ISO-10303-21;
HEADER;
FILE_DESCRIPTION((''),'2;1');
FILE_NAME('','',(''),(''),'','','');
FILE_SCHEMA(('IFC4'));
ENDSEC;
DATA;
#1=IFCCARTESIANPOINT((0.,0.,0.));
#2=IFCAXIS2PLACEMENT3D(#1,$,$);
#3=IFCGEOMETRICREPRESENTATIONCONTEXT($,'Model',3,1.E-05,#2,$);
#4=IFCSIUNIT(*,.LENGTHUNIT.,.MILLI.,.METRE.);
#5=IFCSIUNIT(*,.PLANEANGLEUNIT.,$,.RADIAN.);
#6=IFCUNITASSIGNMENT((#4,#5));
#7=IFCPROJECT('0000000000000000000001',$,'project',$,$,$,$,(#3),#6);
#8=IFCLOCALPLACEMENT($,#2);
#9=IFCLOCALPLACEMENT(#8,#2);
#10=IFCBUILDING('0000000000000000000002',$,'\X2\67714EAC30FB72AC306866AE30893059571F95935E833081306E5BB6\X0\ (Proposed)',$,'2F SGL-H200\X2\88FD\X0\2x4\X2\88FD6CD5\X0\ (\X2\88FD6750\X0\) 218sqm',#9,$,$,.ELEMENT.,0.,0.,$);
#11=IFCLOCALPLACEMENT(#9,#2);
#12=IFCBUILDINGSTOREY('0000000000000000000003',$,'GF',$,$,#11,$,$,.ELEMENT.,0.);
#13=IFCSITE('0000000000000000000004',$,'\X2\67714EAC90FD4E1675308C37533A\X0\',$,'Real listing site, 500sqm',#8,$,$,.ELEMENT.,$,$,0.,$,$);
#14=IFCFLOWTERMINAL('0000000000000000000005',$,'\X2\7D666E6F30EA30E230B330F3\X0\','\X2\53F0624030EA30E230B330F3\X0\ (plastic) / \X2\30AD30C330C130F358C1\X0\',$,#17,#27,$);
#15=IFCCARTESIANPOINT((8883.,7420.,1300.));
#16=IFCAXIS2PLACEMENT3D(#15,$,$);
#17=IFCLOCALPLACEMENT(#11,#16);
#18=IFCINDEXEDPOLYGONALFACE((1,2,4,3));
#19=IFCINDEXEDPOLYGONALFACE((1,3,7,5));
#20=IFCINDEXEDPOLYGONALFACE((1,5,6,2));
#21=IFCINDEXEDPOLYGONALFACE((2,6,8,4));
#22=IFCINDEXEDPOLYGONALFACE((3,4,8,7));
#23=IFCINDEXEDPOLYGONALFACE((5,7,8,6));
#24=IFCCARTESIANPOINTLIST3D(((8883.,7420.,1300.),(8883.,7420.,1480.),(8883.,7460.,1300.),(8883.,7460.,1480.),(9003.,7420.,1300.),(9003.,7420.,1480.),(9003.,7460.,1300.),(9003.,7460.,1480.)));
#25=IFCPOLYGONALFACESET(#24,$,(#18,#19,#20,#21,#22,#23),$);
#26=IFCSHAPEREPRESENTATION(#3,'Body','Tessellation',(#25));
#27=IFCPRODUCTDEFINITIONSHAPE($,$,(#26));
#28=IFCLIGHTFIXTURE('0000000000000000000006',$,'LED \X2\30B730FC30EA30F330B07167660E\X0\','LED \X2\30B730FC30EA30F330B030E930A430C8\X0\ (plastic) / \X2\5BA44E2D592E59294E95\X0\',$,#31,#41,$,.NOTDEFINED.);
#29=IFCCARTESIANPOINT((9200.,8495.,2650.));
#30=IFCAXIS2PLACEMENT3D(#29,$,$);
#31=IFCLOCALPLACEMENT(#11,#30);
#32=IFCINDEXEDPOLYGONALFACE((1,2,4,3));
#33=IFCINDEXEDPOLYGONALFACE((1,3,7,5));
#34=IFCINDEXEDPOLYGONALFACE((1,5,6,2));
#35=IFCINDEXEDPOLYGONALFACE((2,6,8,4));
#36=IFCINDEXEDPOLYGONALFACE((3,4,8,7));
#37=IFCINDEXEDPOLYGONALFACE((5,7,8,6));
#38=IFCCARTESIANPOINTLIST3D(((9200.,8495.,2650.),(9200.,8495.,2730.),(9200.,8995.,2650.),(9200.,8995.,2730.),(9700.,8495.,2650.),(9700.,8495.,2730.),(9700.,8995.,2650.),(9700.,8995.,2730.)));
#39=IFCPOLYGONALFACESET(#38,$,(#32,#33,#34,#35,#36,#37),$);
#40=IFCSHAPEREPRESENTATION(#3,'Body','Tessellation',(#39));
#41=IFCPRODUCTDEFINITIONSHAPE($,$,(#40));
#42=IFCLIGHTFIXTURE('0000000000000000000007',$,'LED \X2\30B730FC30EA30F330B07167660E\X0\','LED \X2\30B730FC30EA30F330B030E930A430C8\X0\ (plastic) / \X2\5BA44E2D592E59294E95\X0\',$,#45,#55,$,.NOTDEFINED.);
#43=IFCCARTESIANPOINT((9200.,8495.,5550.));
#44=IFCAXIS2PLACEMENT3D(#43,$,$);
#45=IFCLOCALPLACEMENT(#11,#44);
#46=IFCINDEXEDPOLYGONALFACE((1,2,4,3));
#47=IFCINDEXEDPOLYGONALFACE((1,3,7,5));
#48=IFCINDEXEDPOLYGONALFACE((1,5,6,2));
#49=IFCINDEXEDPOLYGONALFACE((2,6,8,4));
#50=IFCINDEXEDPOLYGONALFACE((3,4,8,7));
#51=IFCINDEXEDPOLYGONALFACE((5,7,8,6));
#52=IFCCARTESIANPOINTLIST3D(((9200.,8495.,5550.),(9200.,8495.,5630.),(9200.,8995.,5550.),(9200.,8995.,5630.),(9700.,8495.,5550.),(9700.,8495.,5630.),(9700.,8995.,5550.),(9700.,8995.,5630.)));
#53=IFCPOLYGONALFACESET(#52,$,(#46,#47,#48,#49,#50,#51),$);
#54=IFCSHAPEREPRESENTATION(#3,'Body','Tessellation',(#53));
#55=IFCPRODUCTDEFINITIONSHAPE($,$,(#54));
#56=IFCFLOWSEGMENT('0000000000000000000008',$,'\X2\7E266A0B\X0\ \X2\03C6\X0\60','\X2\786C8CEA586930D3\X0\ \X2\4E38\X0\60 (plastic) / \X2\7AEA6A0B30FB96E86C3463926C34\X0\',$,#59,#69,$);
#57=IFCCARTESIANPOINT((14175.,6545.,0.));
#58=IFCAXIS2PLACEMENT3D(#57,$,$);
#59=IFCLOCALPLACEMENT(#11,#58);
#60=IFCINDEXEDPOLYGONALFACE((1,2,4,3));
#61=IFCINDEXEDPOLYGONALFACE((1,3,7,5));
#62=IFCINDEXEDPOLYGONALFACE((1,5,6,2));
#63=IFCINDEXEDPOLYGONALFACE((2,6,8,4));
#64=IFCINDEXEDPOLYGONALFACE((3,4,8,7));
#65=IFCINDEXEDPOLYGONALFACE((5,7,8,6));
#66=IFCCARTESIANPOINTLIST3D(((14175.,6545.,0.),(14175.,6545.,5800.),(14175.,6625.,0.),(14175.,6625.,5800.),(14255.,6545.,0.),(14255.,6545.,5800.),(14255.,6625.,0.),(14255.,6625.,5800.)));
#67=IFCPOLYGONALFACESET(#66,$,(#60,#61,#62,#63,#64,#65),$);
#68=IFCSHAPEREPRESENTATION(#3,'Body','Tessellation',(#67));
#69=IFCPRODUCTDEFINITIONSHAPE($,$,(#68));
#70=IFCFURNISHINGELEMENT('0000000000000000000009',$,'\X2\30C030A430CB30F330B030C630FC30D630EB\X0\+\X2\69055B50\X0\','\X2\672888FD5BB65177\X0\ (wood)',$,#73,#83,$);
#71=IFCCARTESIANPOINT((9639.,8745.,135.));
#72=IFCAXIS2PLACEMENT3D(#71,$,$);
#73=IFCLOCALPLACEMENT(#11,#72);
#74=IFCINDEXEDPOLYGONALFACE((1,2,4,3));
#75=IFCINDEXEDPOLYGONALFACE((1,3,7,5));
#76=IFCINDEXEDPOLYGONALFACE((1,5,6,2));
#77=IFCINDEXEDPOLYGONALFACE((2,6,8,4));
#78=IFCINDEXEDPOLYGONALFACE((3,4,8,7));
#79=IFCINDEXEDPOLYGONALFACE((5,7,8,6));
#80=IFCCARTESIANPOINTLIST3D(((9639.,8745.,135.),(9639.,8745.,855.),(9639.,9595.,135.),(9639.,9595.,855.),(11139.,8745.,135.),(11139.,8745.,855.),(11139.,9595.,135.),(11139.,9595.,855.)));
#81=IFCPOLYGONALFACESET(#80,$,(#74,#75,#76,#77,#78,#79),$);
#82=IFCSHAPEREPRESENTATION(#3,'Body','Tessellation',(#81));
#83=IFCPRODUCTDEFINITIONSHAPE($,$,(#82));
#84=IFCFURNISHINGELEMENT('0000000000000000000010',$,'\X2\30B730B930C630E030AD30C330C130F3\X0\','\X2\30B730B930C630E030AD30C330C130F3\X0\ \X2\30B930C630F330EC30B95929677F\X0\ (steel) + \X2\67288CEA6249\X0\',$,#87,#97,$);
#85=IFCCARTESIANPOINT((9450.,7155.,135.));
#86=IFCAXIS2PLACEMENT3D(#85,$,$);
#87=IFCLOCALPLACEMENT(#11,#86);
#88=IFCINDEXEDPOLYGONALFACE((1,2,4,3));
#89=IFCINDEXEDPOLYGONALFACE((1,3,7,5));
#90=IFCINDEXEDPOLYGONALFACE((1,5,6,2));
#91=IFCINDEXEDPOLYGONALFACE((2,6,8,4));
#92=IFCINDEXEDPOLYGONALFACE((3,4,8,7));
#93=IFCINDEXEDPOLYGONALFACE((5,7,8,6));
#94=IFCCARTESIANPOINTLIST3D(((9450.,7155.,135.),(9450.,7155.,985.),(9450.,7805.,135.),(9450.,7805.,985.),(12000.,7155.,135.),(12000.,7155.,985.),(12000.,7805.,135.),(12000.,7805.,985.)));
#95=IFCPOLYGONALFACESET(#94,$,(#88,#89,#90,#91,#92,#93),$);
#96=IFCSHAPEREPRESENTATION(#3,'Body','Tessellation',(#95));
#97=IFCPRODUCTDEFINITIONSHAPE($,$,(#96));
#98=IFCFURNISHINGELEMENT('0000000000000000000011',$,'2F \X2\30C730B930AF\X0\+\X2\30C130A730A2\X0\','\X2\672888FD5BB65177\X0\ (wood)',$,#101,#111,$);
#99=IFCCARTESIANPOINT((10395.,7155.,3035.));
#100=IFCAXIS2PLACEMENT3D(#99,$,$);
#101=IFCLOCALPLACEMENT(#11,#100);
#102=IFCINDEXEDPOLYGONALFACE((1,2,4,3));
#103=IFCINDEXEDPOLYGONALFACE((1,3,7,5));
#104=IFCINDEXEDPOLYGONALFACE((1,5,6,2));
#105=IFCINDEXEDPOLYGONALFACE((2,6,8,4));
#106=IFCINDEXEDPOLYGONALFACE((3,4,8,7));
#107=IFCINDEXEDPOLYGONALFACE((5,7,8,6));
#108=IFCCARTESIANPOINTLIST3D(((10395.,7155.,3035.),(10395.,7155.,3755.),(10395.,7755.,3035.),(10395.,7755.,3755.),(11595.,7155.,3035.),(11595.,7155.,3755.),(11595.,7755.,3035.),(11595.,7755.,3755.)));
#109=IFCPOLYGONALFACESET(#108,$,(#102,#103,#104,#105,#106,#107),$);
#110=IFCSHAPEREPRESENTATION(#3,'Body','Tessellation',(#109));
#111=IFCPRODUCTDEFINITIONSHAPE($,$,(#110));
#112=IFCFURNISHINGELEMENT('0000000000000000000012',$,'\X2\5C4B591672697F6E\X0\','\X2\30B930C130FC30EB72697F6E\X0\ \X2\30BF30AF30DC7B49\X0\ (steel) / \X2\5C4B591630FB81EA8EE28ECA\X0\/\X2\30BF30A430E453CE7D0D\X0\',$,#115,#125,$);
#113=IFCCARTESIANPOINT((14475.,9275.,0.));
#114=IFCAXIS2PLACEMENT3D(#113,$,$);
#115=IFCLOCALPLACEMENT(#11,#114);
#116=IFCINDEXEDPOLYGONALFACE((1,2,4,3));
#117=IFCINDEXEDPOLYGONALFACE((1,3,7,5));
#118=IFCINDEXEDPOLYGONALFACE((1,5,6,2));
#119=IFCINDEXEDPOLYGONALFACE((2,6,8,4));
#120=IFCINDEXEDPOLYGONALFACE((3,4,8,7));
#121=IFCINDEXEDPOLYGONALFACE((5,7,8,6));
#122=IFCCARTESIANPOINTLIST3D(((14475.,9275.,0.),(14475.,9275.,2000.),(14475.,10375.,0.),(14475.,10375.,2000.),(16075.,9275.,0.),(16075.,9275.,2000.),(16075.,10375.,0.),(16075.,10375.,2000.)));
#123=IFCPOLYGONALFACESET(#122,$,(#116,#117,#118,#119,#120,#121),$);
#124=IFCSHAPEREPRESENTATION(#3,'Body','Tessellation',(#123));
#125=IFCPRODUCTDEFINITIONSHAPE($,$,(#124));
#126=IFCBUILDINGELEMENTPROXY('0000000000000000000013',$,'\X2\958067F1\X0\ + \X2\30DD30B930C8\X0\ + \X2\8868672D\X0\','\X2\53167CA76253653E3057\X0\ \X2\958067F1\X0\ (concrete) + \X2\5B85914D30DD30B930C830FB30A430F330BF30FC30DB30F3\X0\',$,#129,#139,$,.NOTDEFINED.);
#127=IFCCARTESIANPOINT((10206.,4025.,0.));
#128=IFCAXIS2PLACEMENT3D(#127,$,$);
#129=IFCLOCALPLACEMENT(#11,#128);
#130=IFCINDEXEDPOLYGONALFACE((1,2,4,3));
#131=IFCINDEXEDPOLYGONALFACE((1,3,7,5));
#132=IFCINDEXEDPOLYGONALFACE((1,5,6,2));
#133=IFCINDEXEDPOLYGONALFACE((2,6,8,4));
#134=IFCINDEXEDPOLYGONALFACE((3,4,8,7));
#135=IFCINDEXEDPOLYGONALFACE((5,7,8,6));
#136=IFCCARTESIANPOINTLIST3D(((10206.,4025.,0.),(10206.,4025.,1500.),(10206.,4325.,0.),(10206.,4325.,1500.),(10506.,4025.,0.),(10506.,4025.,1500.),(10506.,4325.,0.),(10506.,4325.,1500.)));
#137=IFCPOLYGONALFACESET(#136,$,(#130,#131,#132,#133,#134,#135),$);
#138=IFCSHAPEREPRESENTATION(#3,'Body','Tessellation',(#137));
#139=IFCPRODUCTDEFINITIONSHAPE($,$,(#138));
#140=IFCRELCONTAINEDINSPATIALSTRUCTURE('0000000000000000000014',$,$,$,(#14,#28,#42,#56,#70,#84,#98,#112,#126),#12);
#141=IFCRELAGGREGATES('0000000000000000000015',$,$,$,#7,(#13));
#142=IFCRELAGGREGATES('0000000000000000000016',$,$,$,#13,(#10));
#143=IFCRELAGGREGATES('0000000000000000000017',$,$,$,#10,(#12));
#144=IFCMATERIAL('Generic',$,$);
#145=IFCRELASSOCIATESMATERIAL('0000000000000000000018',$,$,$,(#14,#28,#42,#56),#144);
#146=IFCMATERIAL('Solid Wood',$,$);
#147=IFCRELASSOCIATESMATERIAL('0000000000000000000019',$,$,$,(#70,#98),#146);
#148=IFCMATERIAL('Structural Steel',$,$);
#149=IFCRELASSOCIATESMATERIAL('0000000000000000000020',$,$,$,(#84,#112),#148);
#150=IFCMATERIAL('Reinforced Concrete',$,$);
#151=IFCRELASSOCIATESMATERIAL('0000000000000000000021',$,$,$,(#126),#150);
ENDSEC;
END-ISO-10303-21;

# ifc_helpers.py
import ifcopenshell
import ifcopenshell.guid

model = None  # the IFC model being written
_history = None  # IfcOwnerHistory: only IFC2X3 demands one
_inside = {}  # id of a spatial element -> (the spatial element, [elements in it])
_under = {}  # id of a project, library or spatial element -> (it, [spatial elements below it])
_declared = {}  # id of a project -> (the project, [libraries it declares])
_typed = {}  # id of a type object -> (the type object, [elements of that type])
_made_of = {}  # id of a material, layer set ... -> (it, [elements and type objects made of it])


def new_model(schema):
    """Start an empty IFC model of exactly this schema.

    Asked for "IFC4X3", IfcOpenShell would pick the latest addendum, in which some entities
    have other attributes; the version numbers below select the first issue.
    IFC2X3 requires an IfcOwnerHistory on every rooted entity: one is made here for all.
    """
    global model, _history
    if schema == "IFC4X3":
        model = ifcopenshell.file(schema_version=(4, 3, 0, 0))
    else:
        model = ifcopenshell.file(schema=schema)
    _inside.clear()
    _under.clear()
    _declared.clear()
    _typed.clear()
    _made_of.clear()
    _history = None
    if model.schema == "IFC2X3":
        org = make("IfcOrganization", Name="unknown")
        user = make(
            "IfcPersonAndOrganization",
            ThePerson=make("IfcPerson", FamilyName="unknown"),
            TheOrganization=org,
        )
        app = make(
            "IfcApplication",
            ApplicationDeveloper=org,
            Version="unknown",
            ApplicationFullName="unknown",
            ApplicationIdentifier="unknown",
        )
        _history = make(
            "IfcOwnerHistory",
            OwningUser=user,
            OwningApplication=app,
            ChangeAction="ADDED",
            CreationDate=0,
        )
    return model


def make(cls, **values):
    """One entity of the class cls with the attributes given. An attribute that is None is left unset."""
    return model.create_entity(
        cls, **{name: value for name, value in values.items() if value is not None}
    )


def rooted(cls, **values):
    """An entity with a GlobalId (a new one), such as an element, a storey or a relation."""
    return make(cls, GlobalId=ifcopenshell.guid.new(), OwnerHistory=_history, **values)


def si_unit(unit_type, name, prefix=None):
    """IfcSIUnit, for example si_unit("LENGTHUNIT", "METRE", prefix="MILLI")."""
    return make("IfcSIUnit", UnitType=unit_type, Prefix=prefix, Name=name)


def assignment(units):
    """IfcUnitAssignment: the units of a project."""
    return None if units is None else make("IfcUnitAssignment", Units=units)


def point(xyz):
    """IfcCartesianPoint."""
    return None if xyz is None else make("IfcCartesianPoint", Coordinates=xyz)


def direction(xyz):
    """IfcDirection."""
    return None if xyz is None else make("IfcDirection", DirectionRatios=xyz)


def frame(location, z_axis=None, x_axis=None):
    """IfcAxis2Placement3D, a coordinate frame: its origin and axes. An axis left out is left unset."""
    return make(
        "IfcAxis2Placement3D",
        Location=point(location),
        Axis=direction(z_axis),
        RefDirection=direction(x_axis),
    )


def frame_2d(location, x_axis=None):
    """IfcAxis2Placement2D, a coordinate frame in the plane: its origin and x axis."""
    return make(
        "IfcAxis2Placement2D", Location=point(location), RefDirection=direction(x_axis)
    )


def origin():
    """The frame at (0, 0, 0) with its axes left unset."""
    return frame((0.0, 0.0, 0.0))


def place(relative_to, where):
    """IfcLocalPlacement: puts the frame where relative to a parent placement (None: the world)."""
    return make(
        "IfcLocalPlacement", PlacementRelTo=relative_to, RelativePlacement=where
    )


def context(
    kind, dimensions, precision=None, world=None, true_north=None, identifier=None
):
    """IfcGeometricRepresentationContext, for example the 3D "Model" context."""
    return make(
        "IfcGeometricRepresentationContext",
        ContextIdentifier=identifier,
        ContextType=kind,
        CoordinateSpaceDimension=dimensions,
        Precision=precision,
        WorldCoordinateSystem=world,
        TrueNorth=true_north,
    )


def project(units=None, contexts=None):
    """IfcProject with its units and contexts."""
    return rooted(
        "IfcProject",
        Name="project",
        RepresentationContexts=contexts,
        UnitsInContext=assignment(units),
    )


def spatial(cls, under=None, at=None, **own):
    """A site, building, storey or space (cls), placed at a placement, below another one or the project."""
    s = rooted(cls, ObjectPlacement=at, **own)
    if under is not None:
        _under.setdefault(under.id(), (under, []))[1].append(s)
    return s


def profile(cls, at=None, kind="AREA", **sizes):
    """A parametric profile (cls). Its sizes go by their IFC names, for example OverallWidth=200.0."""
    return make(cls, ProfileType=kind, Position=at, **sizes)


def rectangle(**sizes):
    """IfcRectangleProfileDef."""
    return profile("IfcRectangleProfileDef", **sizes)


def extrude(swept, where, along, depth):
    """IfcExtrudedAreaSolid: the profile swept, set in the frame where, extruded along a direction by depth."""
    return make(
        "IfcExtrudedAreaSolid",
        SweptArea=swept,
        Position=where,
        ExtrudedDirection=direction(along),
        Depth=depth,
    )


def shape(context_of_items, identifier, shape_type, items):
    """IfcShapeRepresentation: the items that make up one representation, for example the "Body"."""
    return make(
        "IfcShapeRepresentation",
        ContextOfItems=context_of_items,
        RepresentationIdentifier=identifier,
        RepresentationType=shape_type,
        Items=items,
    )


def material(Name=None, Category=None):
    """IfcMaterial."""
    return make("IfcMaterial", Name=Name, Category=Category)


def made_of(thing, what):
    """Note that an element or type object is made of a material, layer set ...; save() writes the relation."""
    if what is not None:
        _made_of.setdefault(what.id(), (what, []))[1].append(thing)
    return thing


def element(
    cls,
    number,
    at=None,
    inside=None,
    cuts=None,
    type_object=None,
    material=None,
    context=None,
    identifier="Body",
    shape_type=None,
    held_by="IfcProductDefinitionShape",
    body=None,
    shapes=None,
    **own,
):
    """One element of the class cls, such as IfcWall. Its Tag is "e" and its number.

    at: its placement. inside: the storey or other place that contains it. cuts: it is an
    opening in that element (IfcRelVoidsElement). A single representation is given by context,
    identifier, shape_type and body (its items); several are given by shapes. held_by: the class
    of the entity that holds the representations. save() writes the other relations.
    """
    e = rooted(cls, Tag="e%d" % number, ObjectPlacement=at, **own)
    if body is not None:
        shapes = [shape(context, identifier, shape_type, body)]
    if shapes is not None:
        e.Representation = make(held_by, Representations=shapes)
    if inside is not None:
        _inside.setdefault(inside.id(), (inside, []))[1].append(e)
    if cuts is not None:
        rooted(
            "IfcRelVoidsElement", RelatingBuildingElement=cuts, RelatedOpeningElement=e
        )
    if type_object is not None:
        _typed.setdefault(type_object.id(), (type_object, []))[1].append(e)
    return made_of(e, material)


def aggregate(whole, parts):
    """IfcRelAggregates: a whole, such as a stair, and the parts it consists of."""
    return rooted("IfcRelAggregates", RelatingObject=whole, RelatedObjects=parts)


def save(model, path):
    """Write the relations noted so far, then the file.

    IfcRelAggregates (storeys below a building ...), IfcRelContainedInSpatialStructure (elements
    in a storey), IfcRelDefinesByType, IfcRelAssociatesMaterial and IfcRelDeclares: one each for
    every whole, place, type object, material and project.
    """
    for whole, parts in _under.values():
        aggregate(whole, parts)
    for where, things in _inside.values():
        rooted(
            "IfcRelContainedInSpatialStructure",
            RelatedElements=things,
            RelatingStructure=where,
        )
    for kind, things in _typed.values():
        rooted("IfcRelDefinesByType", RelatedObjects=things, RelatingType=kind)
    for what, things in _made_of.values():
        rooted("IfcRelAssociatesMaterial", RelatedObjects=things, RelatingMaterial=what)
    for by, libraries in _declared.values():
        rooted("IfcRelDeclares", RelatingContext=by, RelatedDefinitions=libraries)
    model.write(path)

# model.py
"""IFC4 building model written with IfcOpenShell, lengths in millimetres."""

from ifc_helpers import new_model, si_unit, frame, frame_2d, origin, place, context, project, spatial, rectangle, extrude, material, element, save


model = new_model("IFC4")

# Units and contexts
model_context = context("Model", 3, precision=1e-05, world=origin())
ifc_project = project(units=[si_unit("LENGTHUNIT", "METRE", prefix="MILLI"), si_unit("PLANEANGLEUNIT", "RADIAN")], contexts=[model_context])

# Site, building, storey
site_placement = place(None, origin())
site = spatial("IfcSite", under=ifc_project, at=site_placement, Name="東京都世田谷区", ObjectType="Real listing site, 500sqm", CompositionType="ELEMENT", RefElevation=0.0)
building_placement = place(site_placement, origin())
building = spatial("IfcBuilding", under=site, at=building_placement, Name="東京・犬と暮らす土間広めの家 (Proposed)", ObjectType="2F SGL-H200製2x4製法 (製材) 218sqm", CompositionType="ELEMENT", ElevationOfRefHeight=0.0, ElevationOfTerrain=0.0)
storey_placement = place(building_placement, origin())
storey = spatial("IfcBuildingStorey", under=building, at=storey_placement, Name="GF", CompositionType="ELEMENT", Elevation=0.0)

# Shared definitions
ifc_material_1 = material(Name="Solid Wood")

# Shared definitions
ifc_material_2 = material(Name="Reinforced Concrete")

# Shared definitions
ifc_material_3 = material(Name="Structural Steel")

# Flow terminal
ifc_material_4 = material(Name="Generic")
flow_terminal_1_placement = place(storey_placement, frame((8883.0, 7420.0, 1300.0)))
element("IfcFlowTerminal", 1, at=flow_terminal_1_placement, inside=storey, material=ifc_material_4, Name="給湯リモコン", Description="台所リモコン (plastic) / キッチン壁", context=model_context, shape_type="SweptSolid", body=[
    extrude(rectangle(XDim=120.0, YDim=40.0, at=frame_2d((60.0, 20.0))), frame((8883.0, 7420.0, 1300.0)), (0.0, 0.0, 1.0), 180.0),
])

# Light fixtures
light_fixture_1_placement = place(storey_placement, frame((9200.0, 8495.0, 2650.0)))
element("IfcLightFixture", 2, at=light_fixture_1_placement, inside=storey, material=ifc_material_4, Name="LED シーリング照明", Description="LED シーリングライト (plastic) / 室中央天井", PredefinedType="NOTDEFINED", context=model_context, shape_type="SweptSolid", body=[
    extrude(rectangle(XDim=500.0, YDim=500.0, at=frame_2d((250.0, 250.0))), frame((9200.0, 8495.0, 2650.0)), (0.0, 0.0, 1.0), 80.0),
])
light_fixture_2_placement = place(storey_placement, frame((9200.0, 8495.0, 5550.0)))
element("IfcLightFixture", 3, at=light_fixture_2_placement, inside=storey, material=ifc_material_4, Name="LED シーリング照明", Description="LED シーリングライト (plastic) / 室中央天井", PredefinedType="NOTDEFINED", context=model_context, shape_type="SweptSolid", body=[
    extrude(rectangle(XDim=500.0, YDim=500.0, at=frame_2d((250.0, 250.0))), frame((9200.0, 8495.0, 5550.0)), (0.0, 0.0, 1.0), 80.0),
])

# Flow segment
flow_segment_placement = place(storey_placement, frame((14175.0, 6545.0, 0.0)))
element("IfcFlowSegment", 4, at=flow_segment_placement, inside=storey, material=ifc_material_4, Name="縦樋 φ60", Description="硬質塩ビ 丸60 (plastic) / 竪樋・雨水排水", context=model_context, shape_type="SweptSolid", body=[
    extrude(rectangle(XDim=80.0, YDim=80.0, at=frame_2d((40.0, 40.0))), frame((14175.0, 6545.0, 0.0)), (0.0, 0.0, 1.0), 5800.0),
])

# Furnishing elements
furnishing_1_placement = place(storey_placement, frame((9639.0, 8745.0, 135.0)))
element("IfcFurnishingElement", 5, at=furnishing_1_placement, inside=storey, material=ifc_material_1, Name="ダイニングテーブル+椅子", Description="木製家具 (wood)", context=model_context, shape_type="SweptSolid", body=[
    extrude(rectangle(XDim=1500.0, YDim=850.0, at=frame_2d((750.0, 425.0))), frame((9639.0, 8745.0, 135.0)), (0.0, 0.0, 1.0), 720.0),
])
furnishing_2_placement = place(storey_placement, frame((9450.0, 7155.0, 135.0)))
element("IfcFurnishingElement", 6, at=furnishing_2_placement, inside=storey, material=ifc_material_3, Name="システムキッチン", Description="システムキッチン ステンレス天板 (steel) + 木質扉", context=model_context, shape_type="SweptSolid", body=[
    extrude(rectangle(XDim=2550.0, YDim=650.0, at=frame_2d((1275.0, 325.0))), frame((9450.0, 7155.0, 135.0)), (0.0, 0.0, 1.0), 850.0),
])
furnishing_3_placement = place(storey_placement, frame((10395.0, 7155.0, 3035.0)))
element("IfcFurnishingElement", 7, at=furnishing_3_placement, inside=storey, material=ifc_material_1, Name="2F デスク+チェア", Description="木製家具 (wood)", context=model_context, shape_type="SweptSolid", body=[
    extrude(rectangle(XDim=1200.0, YDim=600.0, at=frame_2d((600.0, 300.0))), frame((10395.0, 7155.0, 3035.0)), (0.0, 0.0, 1.0), 720.0),
])
furnishing_4_placement = place(storey_placement, frame((14475.0, 9275.0, 0.0)))
element("IfcFurnishingElement", 8, at=furnishing_4_placement, inside=storey, material=ifc_material_3, Name="屋外物置", Description="スチール物置 タクボ等 (steel) / 屋外・自転車/タイヤ収納", context=model_context, shape_type="SweptSolid", body=[
    extrude(rectangle(XDim=1600.0, YDim=1100.0, at=frame_2d((800.0, 550.0))), frame((14475.0, 9275.0, 0.0)), (0.0, 0.0, 1.0), 2000.0),
])

# Building element proxy
proxy_placement = place(storey_placement, frame((10206.0, 4025.0, 0.0)))
element("IfcBuildingElementProxy", 9, at=proxy_placement, inside=storey, material=ifc_material_2, Name="門柱 + ポスト + 表札", Description="化粧打放し 門柱 (concrete) + 宅配ポスト・インターホン", PredefinedType="NOTDEFINED", context=model_context, shape_type="SweptSolid", body=[
    extrude(rectangle(XDim=300.0, YDim=300.0, at=frame_2d((150.0, 150.0))), frame((10206.0, 4025.0, 0.0)), (0.0, 0.0, 1.0), 1500.0),
])

save(model, "model.ifc")
